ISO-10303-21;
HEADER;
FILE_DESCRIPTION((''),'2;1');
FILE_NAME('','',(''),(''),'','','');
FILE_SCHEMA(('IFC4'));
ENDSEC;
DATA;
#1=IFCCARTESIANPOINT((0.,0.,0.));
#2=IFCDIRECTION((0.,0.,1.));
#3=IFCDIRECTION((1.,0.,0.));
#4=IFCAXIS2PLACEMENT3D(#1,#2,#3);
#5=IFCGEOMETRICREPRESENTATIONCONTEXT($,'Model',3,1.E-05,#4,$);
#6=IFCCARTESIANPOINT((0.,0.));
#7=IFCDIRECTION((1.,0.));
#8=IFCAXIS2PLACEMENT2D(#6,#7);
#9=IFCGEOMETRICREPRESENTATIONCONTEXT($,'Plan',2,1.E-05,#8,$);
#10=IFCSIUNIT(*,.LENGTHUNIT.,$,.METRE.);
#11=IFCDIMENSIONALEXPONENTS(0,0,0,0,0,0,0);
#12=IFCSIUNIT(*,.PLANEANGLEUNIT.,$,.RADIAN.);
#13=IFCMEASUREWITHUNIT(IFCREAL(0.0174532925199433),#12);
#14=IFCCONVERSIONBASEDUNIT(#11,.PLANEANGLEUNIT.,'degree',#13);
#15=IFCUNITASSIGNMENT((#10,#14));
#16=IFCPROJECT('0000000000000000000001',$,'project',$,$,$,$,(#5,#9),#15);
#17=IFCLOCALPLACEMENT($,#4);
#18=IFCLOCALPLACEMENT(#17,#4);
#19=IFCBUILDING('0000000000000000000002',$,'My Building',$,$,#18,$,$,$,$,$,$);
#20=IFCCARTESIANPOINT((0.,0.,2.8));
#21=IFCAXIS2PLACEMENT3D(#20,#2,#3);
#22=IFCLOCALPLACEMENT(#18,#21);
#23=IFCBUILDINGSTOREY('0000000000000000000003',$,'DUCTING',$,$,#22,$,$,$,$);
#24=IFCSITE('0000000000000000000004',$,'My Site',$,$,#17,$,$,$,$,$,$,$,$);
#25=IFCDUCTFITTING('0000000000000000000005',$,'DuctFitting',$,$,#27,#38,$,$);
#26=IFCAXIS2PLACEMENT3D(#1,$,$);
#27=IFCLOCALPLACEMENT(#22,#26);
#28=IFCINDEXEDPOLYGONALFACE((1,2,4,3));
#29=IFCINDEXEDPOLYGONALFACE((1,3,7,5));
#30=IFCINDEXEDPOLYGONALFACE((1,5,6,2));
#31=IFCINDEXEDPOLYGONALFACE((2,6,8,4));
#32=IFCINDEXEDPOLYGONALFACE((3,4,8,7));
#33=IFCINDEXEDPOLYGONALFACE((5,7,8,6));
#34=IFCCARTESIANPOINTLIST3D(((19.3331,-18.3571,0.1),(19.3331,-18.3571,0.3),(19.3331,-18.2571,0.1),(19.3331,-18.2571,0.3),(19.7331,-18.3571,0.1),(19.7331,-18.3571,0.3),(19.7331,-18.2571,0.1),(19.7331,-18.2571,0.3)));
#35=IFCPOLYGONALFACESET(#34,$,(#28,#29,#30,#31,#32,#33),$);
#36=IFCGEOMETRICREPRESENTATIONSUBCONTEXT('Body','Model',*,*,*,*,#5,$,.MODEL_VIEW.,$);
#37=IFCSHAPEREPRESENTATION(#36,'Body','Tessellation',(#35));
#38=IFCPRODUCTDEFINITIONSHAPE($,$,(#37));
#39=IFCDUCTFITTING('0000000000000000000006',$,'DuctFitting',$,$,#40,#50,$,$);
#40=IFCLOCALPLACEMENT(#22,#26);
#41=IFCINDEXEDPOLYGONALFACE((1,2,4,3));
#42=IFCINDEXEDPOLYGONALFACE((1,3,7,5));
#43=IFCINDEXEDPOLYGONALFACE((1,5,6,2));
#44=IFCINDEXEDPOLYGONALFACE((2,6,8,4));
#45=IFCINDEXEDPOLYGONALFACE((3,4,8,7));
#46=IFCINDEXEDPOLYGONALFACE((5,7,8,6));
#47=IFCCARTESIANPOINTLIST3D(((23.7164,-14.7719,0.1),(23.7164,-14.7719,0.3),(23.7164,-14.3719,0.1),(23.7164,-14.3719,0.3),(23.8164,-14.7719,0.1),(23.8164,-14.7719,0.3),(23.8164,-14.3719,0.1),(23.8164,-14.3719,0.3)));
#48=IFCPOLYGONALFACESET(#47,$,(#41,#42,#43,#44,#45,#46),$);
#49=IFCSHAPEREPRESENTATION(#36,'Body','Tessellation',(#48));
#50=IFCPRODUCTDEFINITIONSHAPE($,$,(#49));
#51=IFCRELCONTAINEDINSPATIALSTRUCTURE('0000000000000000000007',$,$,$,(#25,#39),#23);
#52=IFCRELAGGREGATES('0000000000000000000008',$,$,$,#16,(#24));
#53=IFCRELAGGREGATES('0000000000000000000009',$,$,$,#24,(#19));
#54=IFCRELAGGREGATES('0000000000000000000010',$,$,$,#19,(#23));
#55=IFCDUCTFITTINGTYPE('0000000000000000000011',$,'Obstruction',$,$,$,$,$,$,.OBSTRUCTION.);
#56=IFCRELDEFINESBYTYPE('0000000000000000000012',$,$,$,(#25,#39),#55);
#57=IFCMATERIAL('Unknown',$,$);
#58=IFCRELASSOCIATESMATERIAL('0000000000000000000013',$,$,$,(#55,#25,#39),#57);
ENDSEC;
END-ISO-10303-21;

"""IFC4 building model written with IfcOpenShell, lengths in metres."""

from ifc_helpers import new_model, entity, si_unit, converted_unit, frame, origin_with_axes, origin_2d_with_axis, place, context, subcontext, project, spatial, rectangle, extrude, material, material_profile, profile_set, profile_usage, type_object, element, save


model = new_model("IFC4")

# Units and contexts
model_context = context("Model", 3, precision=1e-05, world=origin_with_axes())
plan_context = context("Plan", 2, precision=1e-05, world=origin_2d_with_axis())
body_context = subcontext(model_context, "Body", "Model", "MODEL_VIEW")
ifc_project = project(units=[si_unit("LENGTHUNIT", "METRE"), converted_unit("PLANEANGLEUNIT", "degree", entity("IfcReal", 0.0174532925199433), si_unit("PLANEANGLEUNIT", "RADIAN"), dimensions=[0, 0, 0, 0, 0, 0, 0])], contexts=[model_context, plan_context])

# Site, building, storey
site_placement = place(None, origin_with_axes())
site = spatial("IfcSite", under=ifc_project, at=site_placement, Name="My Site")
building_placement = place(site_placement, origin_with_axes())
building = spatial("IfcBuilding", under=site, at=building_placement, Name="My Building")
storey_placement = place(building_placement, frame((0.0, 0.0, 2.8), z_axis=(0.0, 0.0, 1.0), x_axis=(1.0, 0.0, 0.0)))
storey = spatial("IfcBuildingStorey", under=building, at=storey_placement, Name="DUCTING")

# Shared definitions
ifc_material = material(Name="Unknown")

# Duct fittings
ifc_material_profile_1 = material_profile(ifc_material, rectangle(XDim=0.4, YDim=0.2))
ifc_profile_set_1 = profile_set([ifc_material_profile_1])
duct_fitting_type_1 = type_object("IfcDuctFittingType", Name="Obstruction", PredefinedType="OBSTRUCTION", material=ifc_profile_set_1)
ifc_profile_usage_1 = profile_usage(ifc_profile_set_1, cardinal=5)
duct_fitting_1_placement = place(storey_placement, frame((19.5331, -18.2571, 0.2), z_axis=(0.0, -1.0, 0.0), x_axis=(1.0, 0.0, 0.0)))
element("IfcDuctFitting", 1, at=duct_fitting_1_placement, inside=storey, type_object=duct_fitting_type_1, material=ifc_profile_usage_1, Name="DuctFitting", context=body_context, shape_type="SweptSolid", body=[
    extrude(rectangle(XDim=0.4, YDim=0.2), origin_with_axes(), (0.0, 0.0, 1.0), 0.1),
])
ifc_profile_usage_2 = profile_usage(ifc_profile_set_1, cardinal=5)
duct_fitting_2_placement = place(storey_placement, frame((23.7164, -14.5719, 0.2), z_axis=(1.0, 0.0, 0.0), x_axis=(0.0, 1.0, 0.0)))
element("IfcDuctFitting", 2, at=duct_fitting_2_placement, inside=storey, type_object=duct_fitting_type_1, material=ifc_profile_usage_2, Name="DuctFitting", context=body_context, shape_type="SweptSolid", body=[
    extrude(rectangle(XDim=0.4, YDim=0.2), origin_with_axes(), (0.0, 0.0, 1.0), 0.1),
])

save(model, "model.ifc")
